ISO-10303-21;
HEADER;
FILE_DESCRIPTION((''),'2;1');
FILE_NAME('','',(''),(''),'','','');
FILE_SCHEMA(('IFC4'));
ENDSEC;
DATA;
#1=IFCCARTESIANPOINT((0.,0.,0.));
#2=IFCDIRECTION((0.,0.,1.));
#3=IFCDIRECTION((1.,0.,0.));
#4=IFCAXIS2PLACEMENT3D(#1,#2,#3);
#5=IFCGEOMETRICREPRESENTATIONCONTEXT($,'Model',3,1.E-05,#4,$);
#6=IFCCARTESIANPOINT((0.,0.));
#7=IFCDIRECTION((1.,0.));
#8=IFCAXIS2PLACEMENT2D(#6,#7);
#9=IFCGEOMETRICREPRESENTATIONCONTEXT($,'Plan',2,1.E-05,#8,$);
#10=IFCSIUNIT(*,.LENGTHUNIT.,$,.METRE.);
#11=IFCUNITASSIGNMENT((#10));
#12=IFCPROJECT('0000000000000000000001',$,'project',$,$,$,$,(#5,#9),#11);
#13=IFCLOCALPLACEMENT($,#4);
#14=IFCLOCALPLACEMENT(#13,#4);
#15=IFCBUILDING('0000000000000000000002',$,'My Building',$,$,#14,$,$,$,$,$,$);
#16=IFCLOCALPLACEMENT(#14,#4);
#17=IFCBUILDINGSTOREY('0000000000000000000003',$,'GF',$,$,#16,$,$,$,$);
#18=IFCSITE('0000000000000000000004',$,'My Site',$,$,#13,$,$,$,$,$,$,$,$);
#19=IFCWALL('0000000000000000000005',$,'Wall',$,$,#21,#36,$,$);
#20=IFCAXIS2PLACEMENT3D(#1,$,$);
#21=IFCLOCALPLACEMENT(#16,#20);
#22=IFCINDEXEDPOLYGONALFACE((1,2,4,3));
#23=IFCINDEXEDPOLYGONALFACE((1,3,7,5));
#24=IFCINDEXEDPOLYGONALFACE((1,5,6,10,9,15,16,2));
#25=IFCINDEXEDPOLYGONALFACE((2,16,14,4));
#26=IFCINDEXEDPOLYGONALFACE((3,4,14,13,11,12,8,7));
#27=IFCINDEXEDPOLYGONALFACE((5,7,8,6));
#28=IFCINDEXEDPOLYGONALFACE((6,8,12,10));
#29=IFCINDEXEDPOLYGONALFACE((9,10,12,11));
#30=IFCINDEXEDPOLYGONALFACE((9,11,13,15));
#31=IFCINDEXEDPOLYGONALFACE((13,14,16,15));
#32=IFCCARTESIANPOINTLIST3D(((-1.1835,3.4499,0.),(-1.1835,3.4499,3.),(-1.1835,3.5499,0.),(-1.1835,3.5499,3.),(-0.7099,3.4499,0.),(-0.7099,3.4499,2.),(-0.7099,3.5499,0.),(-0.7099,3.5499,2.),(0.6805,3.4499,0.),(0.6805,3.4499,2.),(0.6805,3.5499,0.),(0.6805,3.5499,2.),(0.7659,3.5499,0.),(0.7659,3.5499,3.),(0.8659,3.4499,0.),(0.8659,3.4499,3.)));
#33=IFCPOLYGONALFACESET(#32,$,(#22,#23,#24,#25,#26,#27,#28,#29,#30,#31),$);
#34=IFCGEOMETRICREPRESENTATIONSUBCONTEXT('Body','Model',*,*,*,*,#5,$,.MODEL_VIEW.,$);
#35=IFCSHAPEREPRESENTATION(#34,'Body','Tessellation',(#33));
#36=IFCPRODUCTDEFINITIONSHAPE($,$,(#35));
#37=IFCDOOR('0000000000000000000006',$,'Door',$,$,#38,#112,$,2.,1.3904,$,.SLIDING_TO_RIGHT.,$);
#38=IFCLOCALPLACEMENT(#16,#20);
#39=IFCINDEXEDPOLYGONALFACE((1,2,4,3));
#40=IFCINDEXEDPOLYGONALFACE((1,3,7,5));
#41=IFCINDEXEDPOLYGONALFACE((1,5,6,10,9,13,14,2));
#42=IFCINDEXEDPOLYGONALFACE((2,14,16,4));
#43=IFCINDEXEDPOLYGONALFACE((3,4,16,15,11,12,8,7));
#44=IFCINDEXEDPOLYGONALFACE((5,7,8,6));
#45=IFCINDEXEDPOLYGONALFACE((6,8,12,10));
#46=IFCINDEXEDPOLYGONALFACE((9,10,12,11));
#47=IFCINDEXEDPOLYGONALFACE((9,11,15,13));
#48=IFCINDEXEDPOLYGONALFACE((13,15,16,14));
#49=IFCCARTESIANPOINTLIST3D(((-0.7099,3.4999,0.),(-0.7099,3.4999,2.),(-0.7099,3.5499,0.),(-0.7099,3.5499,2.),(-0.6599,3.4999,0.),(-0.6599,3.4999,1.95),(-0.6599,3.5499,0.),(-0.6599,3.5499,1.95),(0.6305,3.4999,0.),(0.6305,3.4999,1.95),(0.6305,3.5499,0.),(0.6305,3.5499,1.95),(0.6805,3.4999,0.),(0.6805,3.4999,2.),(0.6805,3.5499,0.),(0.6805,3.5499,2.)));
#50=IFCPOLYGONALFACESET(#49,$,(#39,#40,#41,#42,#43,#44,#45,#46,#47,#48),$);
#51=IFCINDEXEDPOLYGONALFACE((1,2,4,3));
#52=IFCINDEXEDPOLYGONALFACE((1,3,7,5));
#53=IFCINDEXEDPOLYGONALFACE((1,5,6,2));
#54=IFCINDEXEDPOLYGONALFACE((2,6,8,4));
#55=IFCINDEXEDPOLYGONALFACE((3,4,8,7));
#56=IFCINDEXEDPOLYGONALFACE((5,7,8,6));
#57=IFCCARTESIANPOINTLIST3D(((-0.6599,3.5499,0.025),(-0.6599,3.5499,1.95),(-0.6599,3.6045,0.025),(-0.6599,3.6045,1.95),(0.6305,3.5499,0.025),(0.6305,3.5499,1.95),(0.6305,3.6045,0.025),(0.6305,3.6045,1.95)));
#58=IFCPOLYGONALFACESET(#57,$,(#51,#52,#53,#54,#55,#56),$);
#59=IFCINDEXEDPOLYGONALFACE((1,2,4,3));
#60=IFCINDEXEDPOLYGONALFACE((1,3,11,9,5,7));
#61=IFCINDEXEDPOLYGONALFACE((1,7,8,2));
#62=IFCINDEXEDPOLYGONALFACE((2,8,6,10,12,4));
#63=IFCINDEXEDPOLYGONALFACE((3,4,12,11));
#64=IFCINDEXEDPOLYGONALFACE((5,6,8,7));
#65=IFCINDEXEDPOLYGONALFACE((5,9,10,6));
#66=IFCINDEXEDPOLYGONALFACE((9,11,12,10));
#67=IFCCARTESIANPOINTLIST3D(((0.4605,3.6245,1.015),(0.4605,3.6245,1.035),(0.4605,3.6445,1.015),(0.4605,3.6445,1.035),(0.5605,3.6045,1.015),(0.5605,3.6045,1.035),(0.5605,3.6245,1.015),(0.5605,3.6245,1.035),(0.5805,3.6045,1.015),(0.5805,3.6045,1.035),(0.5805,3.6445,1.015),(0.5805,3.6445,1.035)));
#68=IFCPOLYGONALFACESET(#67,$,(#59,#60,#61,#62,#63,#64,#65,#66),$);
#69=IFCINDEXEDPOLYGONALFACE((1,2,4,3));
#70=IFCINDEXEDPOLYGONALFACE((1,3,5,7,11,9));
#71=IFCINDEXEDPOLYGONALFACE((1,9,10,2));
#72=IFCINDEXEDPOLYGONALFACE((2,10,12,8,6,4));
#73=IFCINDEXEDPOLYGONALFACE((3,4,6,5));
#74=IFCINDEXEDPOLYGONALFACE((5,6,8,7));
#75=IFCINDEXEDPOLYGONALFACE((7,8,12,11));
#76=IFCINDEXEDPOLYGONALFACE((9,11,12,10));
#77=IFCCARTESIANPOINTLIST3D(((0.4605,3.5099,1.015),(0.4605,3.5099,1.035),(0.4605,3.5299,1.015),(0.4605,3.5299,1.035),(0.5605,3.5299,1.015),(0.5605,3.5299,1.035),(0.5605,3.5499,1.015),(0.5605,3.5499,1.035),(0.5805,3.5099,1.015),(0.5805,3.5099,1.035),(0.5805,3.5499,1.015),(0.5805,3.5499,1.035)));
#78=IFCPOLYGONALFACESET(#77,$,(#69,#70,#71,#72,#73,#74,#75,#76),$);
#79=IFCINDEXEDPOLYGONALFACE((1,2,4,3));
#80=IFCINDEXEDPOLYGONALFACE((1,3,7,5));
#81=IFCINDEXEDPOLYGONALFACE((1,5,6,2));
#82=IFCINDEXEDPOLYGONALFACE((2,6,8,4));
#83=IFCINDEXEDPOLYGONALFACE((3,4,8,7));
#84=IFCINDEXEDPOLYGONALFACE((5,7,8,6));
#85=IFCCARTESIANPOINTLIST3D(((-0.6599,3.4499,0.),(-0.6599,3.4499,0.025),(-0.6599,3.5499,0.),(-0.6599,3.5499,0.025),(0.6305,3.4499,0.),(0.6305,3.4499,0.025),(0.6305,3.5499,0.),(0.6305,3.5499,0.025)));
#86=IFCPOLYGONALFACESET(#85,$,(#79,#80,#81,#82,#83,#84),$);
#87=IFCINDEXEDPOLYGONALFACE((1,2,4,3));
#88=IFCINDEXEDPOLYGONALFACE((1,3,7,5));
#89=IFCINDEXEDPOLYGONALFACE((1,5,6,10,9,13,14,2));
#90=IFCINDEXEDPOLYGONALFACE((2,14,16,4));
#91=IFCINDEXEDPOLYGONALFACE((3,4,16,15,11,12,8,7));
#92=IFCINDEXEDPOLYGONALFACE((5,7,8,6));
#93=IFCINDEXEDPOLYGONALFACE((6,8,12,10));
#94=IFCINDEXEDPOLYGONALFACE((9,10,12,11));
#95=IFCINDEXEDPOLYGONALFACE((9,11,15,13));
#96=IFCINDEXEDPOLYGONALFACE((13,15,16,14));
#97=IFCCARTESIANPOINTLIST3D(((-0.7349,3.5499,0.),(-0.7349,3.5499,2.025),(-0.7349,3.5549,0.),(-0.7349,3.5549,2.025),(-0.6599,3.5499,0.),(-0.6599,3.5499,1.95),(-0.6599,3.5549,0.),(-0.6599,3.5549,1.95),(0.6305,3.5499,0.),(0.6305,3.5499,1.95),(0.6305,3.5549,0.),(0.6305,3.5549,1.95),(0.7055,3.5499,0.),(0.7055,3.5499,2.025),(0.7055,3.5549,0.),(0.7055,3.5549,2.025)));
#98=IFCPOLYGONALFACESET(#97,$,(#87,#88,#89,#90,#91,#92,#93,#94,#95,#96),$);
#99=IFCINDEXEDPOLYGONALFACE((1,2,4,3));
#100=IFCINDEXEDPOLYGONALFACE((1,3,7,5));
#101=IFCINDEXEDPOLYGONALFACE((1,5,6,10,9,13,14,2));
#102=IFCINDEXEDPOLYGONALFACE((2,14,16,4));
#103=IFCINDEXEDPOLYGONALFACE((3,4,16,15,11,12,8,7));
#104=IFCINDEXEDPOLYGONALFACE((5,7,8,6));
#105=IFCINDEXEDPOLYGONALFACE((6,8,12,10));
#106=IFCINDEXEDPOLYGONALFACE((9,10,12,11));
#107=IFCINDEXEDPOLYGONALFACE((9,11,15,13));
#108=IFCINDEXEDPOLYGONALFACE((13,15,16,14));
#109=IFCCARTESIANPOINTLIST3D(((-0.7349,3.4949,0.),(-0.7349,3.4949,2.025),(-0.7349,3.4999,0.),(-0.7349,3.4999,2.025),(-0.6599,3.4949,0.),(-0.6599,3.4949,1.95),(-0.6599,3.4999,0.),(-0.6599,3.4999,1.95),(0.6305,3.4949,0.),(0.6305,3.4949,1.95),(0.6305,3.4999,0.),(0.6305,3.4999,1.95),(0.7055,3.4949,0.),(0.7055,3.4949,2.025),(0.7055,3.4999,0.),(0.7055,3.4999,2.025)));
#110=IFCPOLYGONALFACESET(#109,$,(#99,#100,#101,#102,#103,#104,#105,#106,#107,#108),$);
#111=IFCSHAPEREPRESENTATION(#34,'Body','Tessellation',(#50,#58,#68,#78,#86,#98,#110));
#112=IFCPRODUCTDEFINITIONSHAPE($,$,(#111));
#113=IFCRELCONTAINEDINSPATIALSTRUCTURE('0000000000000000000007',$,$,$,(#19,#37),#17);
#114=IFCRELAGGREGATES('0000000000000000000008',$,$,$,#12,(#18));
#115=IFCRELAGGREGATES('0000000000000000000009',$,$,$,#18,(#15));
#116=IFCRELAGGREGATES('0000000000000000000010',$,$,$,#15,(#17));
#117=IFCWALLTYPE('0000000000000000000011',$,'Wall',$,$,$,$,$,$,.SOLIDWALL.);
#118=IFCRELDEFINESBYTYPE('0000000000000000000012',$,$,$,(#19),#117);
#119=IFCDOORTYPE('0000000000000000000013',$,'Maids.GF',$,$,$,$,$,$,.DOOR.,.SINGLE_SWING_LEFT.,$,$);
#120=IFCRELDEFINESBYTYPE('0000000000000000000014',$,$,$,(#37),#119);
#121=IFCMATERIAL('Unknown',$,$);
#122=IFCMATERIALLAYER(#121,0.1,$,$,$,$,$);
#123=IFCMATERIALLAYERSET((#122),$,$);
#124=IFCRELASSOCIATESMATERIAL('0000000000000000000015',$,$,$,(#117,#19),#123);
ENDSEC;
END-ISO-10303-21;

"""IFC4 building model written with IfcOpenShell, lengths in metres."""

from ifc_helpers import new_model, entity, si_unit, frame, origin_with_axes, origin_2d_with_axis, place, context, subcontext, project, spatial, line, indexed_curve, outline, extrude, shape, source, transform, mapped, material, layer, layer_set, layer_usage, type_object, type_shapes, element, fill, save


model = new_model("IFC4")

# Units and contexts
model_context = context("Model", 3, precision=1e-05, world=origin_with_axes())
plan_context = context("Plan", 2, precision=1e-05, world=origin_2d_with_axis())
body_context_1 = subcontext(model_context, "Body", "Model", "MODEL_VIEW")
body_context_2 = subcontext(plan_context, "Body", "Plan", "PLAN_VIEW")
ifc_project = project(units=[si_unit("LENGTHUNIT", "METRE")], contexts=[model_context, plan_context])

# Site, building, storey
site_placement = place(None, origin_with_axes())
site = spatial("IfcSite", under=ifc_project, at=site_placement, Name="My Site")
building_placement = place(site_placement, origin_with_axes())
building = spatial("IfcBuilding", under=site, at=building_placement, Name="My Building")
storey_placement = place(building_placement, origin_with_axes())
storey = spatial("IfcBuildingStorey", under=building, at=storey_placement, Name="GF")

# Shared definitions
ifc_material_1 = material(Name="Unknown")

# Shared definitions
ifc_layer_1 = layer(ifc_material_1, 0.1)
ifc_layer_set_1 = layer_set([ifc_layer_1])
wall_type = type_object("IfcWallType", Name="Wall", PredefinedType="SOLIDWALL", material=ifc_layer_set_1)

# Wall, opening, door
ifc_layer_usage_1 = layer_usage(ifc_layer_set_1, "AXIS2", "POSITIVE", 0.0)
wall_1_placement = place(storey_placement, frame((0.7659, 3.5499, 0.0), z_axis=(0.0, 0.0, 1.0), x_axis=(-1.0, 0.0, 0.0)))
wall_1 = element("IfcWall", 1, at=wall_1_placement, inside=storey, type_object=wall_type, material=ifc_layer_usage_1, Name="Wall", context=body_context_1, shape_type="SweptSolid", body=[
    extrude(outline(indexed_curve([(0.0, 0.0), (-0.1, 0.1), (1.9494, 0.1), (1.9494, 0.0)], segments=[line(1, 2, 3, 4, 1)])), origin_with_axes(), (0.0, 0.0, 1.0), 3.0),
])
shared_shape_1 = source(origin_with_axes(), body_context_1, "Body", "SweptSolid", [
    extrude(outline(indexed_curve([(0.0, 0.0), (1.3904, 0.0), (1.3904, 2.0), (0.0, 2.0)], segments=[line(1, 2, 3, 4, 1)])), frame((0.0, -0.6, 0.0), z_axis=(0.0, -1.0, 0.0), x_axis=(1.0, 0.0, 0.0)), (0.0, 0.0, -1.0), 1.2),
])
opening_1_placement = place(wall_1_placement, frame((0.0853, 0.0, 0.0), z_axis=(0.0, 0.0, 1.0), x_axis=(1.0, 0.0, 0.0)))
opening_1 = element("IfcOpeningElement", 2, at=opening_1_placement, cuts=wall_1, PredefinedType="OPENING", context=body_context_1, shape_type="MappedRepresentation", body=[
    mapped(shared_shape_1, transform((0.0, 0.0, 0.0), x_axis=(1.0, 0.0, 0.0), y_axis=(0.0, 1.0, 0.0), z_axis=(0.0, 0.0, 1.0), scale=1.0)),
])
door_type_1 = type_object("IfcDoorType", Name="Maids.GF", OperationType="SINGLE_SWING_LEFT", PredefinedType="DOOR")
shared_shape_2 = source(origin_with_axes(), body_context_1, "Body", "SweptSolid", [
    extrude(outline(indexed_curve([(0.0, 0.0), (0.0, 2.0), (1.3904, 2.0), (1.3904, 0.0), (1.3404, 0.0), (1.3404, 1.95), (0.05, 1.95), (0.05, 0.0)], segments=[line(1, 2, 3, 4, 5, 6, 7, 8, 1)])), frame((0.0, 0.0, 0.0), z_axis=(0.0, -1.0, 0.0), x_axis=(1.0, 0.0, 0.0)), (0.0, 0.0, -1.0), 0.05),
    extrude(outline(indexed_curve([(0.0, 0.0), (1.2904, 0.0), (1.2904, 0.0547), (0.0, 0.0547)], segments=[line(1, 2, 3, 4, 1)])), frame((0.05, -0.0547, 0.025), z_axis=(0.0, 0.0, 1.0), x_axis=(1.0, 0.0, 0.0)), (0.0, 0.0, 1.0), 1.925),
    extrude(outline(indexed_curve([(0.0, 0.0), (0.0, -0.04), (0.12, -0.04), (0.12, -0.02), (0.02, -0.02), (0.02, 0.0)], segments=[line(1, 2, 3, 4, 5, 6, 1)])), frame((0.1, -0.0547, 1.015), z_axis=(0.0, 0.0, 1.0), x_axis=(1.0, 0.0, 0.0)), (0.0, 0.0, 1.0), 0.02),
    extrude(outline(indexed_curve([(0.0, 0.0), (0.0, 0.04), (0.12, 0.04), (0.12, 0.02), (0.02, 0.02), (0.02, 0.0)], segments=[line(1, 2, 3, 4, 5, 6, 1)])), frame((0.1, 0.0, 1.015), z_axis=(0.0, 0.0, 1.0), x_axis=(1.0, 0.0, 0.0)), (0.0, 0.0, 1.0), 0.02),
    extrude(outline(indexed_curve([(0.0, 0.0), (1.2904, 0.0), (1.2904, 0.1), (0.0, 0.1)], segments=[line(1, 2, 3, 4, 1)])), frame((0.05, 0.0, 0.0), z_axis=(0.0, 0.0, 1.0), x_axis=(1.0, 0.0, 0.0)), (0.0, 0.0, 1.0), 0.025),
    extrude(outline(indexed_curve([(0.0, 0.0), (0.0, 2.025), (1.4404, 2.025), (1.4404, 0.0), (1.3654, 0.0), (1.3654, 1.95), (0.075, 1.95), (0.075, 0.0)], segments=[line(1, 2, 3, 4, 5, 6, 7, 8, 1)])), frame((-0.025, -0.005, 0.0), z_axis=(0.0, -1.0, 0.0), x_axis=(1.0, 0.0, 0.0)), (0.0, 0.0, -1.0), 0.005),
    extrude(outline(indexed_curve([(0.0, 0.0), (0.0, 2.025), (1.4404, 2.025), (1.4404, 0.0), (1.3654, 0.0), (1.3654, 1.95), (0.075, 1.95), (0.075, 0.0)], segments=[line(1, 2, 3, 4, 5, 6, 7, 8, 1)])), frame((-0.025, 0.05, 0.0), z_axis=(0.0, -1.0, 0.0), x_axis=(1.0, 0.0, 0.0)), (0.0, 0.0, -1.0), 0.005),
])
shared_shape_3 = source(origin_with_axes(), body_context_2, "Body", "Curve2D", [
    entity("IfcIndexedPolyCurve", entity("IfcCartesianPointList2D", [[0.0, 0.0], [0.05, 0.0], [0.05, 0.05], [0.0, 0.05]]), [entity("IfcLineIndex", [1, 2, 3, 4, 1])]),
    entity("IfcIndexedPolyCurve", entity("IfcCartesianPointList2D", [[1.3904, 0.0], [1.3404, 0.0], [1.3404, 0.05], [1.3904, 0.05]]), [entity("IfcLineIndex", [1, 2, 3, 4, 1])]),
    entity("IfcIndexedPolyCurve", entity("IfcCartesianPointList2D", [[1.9856, -0.0547], [0.6952, -0.0547], [0.6952, 0.0], [1.9856, 0.0]]), [entity("IfcLineIndex", [1, 2, 3, 4, 1])]),
])
type_shapes(door_type_1, [shared_shape_2, shared_shape_3])
door_1_placement = place(opening_1_placement, frame((0.0, 0.0, 0.0), z_axis=(0.0, 0.0, 1.0), x_axis=(1.0, 0.0, 0.0)))
door_1 = element("IfcDoor", 3, at=door_1_placement, inside=storey, type_object=door_type_1, Name="Door", OperationType="SLIDING_TO_RIGHT", OverallHeight=2.0, OverallWidth=1.3904, shapes=[
    shape(body_context_1, "Body", "MappedRepresentation", [mapped(shared_shape_2, transform((0.0, 0.0, 0.0), x_axis=(1.0, 0.0, 0.0), y_axis=(0.0, 1.0, 0.0), z_axis=(0.0, 0.0, 1.0), scale=1.0))]),
    shape(body_context_2, "Body", "MappedRepresentation", [mapped(shared_shape_3, transform((0.0, 0.0, 0.0), x_axis=(1.0, 0.0, 0.0), y_axis=(0.0, 1.0, 0.0), z_axis=(0.0, 0.0, 1.0), scale=1.0))]),
])
fill(opening_1, door_1)

save(model, "model.ifc")
